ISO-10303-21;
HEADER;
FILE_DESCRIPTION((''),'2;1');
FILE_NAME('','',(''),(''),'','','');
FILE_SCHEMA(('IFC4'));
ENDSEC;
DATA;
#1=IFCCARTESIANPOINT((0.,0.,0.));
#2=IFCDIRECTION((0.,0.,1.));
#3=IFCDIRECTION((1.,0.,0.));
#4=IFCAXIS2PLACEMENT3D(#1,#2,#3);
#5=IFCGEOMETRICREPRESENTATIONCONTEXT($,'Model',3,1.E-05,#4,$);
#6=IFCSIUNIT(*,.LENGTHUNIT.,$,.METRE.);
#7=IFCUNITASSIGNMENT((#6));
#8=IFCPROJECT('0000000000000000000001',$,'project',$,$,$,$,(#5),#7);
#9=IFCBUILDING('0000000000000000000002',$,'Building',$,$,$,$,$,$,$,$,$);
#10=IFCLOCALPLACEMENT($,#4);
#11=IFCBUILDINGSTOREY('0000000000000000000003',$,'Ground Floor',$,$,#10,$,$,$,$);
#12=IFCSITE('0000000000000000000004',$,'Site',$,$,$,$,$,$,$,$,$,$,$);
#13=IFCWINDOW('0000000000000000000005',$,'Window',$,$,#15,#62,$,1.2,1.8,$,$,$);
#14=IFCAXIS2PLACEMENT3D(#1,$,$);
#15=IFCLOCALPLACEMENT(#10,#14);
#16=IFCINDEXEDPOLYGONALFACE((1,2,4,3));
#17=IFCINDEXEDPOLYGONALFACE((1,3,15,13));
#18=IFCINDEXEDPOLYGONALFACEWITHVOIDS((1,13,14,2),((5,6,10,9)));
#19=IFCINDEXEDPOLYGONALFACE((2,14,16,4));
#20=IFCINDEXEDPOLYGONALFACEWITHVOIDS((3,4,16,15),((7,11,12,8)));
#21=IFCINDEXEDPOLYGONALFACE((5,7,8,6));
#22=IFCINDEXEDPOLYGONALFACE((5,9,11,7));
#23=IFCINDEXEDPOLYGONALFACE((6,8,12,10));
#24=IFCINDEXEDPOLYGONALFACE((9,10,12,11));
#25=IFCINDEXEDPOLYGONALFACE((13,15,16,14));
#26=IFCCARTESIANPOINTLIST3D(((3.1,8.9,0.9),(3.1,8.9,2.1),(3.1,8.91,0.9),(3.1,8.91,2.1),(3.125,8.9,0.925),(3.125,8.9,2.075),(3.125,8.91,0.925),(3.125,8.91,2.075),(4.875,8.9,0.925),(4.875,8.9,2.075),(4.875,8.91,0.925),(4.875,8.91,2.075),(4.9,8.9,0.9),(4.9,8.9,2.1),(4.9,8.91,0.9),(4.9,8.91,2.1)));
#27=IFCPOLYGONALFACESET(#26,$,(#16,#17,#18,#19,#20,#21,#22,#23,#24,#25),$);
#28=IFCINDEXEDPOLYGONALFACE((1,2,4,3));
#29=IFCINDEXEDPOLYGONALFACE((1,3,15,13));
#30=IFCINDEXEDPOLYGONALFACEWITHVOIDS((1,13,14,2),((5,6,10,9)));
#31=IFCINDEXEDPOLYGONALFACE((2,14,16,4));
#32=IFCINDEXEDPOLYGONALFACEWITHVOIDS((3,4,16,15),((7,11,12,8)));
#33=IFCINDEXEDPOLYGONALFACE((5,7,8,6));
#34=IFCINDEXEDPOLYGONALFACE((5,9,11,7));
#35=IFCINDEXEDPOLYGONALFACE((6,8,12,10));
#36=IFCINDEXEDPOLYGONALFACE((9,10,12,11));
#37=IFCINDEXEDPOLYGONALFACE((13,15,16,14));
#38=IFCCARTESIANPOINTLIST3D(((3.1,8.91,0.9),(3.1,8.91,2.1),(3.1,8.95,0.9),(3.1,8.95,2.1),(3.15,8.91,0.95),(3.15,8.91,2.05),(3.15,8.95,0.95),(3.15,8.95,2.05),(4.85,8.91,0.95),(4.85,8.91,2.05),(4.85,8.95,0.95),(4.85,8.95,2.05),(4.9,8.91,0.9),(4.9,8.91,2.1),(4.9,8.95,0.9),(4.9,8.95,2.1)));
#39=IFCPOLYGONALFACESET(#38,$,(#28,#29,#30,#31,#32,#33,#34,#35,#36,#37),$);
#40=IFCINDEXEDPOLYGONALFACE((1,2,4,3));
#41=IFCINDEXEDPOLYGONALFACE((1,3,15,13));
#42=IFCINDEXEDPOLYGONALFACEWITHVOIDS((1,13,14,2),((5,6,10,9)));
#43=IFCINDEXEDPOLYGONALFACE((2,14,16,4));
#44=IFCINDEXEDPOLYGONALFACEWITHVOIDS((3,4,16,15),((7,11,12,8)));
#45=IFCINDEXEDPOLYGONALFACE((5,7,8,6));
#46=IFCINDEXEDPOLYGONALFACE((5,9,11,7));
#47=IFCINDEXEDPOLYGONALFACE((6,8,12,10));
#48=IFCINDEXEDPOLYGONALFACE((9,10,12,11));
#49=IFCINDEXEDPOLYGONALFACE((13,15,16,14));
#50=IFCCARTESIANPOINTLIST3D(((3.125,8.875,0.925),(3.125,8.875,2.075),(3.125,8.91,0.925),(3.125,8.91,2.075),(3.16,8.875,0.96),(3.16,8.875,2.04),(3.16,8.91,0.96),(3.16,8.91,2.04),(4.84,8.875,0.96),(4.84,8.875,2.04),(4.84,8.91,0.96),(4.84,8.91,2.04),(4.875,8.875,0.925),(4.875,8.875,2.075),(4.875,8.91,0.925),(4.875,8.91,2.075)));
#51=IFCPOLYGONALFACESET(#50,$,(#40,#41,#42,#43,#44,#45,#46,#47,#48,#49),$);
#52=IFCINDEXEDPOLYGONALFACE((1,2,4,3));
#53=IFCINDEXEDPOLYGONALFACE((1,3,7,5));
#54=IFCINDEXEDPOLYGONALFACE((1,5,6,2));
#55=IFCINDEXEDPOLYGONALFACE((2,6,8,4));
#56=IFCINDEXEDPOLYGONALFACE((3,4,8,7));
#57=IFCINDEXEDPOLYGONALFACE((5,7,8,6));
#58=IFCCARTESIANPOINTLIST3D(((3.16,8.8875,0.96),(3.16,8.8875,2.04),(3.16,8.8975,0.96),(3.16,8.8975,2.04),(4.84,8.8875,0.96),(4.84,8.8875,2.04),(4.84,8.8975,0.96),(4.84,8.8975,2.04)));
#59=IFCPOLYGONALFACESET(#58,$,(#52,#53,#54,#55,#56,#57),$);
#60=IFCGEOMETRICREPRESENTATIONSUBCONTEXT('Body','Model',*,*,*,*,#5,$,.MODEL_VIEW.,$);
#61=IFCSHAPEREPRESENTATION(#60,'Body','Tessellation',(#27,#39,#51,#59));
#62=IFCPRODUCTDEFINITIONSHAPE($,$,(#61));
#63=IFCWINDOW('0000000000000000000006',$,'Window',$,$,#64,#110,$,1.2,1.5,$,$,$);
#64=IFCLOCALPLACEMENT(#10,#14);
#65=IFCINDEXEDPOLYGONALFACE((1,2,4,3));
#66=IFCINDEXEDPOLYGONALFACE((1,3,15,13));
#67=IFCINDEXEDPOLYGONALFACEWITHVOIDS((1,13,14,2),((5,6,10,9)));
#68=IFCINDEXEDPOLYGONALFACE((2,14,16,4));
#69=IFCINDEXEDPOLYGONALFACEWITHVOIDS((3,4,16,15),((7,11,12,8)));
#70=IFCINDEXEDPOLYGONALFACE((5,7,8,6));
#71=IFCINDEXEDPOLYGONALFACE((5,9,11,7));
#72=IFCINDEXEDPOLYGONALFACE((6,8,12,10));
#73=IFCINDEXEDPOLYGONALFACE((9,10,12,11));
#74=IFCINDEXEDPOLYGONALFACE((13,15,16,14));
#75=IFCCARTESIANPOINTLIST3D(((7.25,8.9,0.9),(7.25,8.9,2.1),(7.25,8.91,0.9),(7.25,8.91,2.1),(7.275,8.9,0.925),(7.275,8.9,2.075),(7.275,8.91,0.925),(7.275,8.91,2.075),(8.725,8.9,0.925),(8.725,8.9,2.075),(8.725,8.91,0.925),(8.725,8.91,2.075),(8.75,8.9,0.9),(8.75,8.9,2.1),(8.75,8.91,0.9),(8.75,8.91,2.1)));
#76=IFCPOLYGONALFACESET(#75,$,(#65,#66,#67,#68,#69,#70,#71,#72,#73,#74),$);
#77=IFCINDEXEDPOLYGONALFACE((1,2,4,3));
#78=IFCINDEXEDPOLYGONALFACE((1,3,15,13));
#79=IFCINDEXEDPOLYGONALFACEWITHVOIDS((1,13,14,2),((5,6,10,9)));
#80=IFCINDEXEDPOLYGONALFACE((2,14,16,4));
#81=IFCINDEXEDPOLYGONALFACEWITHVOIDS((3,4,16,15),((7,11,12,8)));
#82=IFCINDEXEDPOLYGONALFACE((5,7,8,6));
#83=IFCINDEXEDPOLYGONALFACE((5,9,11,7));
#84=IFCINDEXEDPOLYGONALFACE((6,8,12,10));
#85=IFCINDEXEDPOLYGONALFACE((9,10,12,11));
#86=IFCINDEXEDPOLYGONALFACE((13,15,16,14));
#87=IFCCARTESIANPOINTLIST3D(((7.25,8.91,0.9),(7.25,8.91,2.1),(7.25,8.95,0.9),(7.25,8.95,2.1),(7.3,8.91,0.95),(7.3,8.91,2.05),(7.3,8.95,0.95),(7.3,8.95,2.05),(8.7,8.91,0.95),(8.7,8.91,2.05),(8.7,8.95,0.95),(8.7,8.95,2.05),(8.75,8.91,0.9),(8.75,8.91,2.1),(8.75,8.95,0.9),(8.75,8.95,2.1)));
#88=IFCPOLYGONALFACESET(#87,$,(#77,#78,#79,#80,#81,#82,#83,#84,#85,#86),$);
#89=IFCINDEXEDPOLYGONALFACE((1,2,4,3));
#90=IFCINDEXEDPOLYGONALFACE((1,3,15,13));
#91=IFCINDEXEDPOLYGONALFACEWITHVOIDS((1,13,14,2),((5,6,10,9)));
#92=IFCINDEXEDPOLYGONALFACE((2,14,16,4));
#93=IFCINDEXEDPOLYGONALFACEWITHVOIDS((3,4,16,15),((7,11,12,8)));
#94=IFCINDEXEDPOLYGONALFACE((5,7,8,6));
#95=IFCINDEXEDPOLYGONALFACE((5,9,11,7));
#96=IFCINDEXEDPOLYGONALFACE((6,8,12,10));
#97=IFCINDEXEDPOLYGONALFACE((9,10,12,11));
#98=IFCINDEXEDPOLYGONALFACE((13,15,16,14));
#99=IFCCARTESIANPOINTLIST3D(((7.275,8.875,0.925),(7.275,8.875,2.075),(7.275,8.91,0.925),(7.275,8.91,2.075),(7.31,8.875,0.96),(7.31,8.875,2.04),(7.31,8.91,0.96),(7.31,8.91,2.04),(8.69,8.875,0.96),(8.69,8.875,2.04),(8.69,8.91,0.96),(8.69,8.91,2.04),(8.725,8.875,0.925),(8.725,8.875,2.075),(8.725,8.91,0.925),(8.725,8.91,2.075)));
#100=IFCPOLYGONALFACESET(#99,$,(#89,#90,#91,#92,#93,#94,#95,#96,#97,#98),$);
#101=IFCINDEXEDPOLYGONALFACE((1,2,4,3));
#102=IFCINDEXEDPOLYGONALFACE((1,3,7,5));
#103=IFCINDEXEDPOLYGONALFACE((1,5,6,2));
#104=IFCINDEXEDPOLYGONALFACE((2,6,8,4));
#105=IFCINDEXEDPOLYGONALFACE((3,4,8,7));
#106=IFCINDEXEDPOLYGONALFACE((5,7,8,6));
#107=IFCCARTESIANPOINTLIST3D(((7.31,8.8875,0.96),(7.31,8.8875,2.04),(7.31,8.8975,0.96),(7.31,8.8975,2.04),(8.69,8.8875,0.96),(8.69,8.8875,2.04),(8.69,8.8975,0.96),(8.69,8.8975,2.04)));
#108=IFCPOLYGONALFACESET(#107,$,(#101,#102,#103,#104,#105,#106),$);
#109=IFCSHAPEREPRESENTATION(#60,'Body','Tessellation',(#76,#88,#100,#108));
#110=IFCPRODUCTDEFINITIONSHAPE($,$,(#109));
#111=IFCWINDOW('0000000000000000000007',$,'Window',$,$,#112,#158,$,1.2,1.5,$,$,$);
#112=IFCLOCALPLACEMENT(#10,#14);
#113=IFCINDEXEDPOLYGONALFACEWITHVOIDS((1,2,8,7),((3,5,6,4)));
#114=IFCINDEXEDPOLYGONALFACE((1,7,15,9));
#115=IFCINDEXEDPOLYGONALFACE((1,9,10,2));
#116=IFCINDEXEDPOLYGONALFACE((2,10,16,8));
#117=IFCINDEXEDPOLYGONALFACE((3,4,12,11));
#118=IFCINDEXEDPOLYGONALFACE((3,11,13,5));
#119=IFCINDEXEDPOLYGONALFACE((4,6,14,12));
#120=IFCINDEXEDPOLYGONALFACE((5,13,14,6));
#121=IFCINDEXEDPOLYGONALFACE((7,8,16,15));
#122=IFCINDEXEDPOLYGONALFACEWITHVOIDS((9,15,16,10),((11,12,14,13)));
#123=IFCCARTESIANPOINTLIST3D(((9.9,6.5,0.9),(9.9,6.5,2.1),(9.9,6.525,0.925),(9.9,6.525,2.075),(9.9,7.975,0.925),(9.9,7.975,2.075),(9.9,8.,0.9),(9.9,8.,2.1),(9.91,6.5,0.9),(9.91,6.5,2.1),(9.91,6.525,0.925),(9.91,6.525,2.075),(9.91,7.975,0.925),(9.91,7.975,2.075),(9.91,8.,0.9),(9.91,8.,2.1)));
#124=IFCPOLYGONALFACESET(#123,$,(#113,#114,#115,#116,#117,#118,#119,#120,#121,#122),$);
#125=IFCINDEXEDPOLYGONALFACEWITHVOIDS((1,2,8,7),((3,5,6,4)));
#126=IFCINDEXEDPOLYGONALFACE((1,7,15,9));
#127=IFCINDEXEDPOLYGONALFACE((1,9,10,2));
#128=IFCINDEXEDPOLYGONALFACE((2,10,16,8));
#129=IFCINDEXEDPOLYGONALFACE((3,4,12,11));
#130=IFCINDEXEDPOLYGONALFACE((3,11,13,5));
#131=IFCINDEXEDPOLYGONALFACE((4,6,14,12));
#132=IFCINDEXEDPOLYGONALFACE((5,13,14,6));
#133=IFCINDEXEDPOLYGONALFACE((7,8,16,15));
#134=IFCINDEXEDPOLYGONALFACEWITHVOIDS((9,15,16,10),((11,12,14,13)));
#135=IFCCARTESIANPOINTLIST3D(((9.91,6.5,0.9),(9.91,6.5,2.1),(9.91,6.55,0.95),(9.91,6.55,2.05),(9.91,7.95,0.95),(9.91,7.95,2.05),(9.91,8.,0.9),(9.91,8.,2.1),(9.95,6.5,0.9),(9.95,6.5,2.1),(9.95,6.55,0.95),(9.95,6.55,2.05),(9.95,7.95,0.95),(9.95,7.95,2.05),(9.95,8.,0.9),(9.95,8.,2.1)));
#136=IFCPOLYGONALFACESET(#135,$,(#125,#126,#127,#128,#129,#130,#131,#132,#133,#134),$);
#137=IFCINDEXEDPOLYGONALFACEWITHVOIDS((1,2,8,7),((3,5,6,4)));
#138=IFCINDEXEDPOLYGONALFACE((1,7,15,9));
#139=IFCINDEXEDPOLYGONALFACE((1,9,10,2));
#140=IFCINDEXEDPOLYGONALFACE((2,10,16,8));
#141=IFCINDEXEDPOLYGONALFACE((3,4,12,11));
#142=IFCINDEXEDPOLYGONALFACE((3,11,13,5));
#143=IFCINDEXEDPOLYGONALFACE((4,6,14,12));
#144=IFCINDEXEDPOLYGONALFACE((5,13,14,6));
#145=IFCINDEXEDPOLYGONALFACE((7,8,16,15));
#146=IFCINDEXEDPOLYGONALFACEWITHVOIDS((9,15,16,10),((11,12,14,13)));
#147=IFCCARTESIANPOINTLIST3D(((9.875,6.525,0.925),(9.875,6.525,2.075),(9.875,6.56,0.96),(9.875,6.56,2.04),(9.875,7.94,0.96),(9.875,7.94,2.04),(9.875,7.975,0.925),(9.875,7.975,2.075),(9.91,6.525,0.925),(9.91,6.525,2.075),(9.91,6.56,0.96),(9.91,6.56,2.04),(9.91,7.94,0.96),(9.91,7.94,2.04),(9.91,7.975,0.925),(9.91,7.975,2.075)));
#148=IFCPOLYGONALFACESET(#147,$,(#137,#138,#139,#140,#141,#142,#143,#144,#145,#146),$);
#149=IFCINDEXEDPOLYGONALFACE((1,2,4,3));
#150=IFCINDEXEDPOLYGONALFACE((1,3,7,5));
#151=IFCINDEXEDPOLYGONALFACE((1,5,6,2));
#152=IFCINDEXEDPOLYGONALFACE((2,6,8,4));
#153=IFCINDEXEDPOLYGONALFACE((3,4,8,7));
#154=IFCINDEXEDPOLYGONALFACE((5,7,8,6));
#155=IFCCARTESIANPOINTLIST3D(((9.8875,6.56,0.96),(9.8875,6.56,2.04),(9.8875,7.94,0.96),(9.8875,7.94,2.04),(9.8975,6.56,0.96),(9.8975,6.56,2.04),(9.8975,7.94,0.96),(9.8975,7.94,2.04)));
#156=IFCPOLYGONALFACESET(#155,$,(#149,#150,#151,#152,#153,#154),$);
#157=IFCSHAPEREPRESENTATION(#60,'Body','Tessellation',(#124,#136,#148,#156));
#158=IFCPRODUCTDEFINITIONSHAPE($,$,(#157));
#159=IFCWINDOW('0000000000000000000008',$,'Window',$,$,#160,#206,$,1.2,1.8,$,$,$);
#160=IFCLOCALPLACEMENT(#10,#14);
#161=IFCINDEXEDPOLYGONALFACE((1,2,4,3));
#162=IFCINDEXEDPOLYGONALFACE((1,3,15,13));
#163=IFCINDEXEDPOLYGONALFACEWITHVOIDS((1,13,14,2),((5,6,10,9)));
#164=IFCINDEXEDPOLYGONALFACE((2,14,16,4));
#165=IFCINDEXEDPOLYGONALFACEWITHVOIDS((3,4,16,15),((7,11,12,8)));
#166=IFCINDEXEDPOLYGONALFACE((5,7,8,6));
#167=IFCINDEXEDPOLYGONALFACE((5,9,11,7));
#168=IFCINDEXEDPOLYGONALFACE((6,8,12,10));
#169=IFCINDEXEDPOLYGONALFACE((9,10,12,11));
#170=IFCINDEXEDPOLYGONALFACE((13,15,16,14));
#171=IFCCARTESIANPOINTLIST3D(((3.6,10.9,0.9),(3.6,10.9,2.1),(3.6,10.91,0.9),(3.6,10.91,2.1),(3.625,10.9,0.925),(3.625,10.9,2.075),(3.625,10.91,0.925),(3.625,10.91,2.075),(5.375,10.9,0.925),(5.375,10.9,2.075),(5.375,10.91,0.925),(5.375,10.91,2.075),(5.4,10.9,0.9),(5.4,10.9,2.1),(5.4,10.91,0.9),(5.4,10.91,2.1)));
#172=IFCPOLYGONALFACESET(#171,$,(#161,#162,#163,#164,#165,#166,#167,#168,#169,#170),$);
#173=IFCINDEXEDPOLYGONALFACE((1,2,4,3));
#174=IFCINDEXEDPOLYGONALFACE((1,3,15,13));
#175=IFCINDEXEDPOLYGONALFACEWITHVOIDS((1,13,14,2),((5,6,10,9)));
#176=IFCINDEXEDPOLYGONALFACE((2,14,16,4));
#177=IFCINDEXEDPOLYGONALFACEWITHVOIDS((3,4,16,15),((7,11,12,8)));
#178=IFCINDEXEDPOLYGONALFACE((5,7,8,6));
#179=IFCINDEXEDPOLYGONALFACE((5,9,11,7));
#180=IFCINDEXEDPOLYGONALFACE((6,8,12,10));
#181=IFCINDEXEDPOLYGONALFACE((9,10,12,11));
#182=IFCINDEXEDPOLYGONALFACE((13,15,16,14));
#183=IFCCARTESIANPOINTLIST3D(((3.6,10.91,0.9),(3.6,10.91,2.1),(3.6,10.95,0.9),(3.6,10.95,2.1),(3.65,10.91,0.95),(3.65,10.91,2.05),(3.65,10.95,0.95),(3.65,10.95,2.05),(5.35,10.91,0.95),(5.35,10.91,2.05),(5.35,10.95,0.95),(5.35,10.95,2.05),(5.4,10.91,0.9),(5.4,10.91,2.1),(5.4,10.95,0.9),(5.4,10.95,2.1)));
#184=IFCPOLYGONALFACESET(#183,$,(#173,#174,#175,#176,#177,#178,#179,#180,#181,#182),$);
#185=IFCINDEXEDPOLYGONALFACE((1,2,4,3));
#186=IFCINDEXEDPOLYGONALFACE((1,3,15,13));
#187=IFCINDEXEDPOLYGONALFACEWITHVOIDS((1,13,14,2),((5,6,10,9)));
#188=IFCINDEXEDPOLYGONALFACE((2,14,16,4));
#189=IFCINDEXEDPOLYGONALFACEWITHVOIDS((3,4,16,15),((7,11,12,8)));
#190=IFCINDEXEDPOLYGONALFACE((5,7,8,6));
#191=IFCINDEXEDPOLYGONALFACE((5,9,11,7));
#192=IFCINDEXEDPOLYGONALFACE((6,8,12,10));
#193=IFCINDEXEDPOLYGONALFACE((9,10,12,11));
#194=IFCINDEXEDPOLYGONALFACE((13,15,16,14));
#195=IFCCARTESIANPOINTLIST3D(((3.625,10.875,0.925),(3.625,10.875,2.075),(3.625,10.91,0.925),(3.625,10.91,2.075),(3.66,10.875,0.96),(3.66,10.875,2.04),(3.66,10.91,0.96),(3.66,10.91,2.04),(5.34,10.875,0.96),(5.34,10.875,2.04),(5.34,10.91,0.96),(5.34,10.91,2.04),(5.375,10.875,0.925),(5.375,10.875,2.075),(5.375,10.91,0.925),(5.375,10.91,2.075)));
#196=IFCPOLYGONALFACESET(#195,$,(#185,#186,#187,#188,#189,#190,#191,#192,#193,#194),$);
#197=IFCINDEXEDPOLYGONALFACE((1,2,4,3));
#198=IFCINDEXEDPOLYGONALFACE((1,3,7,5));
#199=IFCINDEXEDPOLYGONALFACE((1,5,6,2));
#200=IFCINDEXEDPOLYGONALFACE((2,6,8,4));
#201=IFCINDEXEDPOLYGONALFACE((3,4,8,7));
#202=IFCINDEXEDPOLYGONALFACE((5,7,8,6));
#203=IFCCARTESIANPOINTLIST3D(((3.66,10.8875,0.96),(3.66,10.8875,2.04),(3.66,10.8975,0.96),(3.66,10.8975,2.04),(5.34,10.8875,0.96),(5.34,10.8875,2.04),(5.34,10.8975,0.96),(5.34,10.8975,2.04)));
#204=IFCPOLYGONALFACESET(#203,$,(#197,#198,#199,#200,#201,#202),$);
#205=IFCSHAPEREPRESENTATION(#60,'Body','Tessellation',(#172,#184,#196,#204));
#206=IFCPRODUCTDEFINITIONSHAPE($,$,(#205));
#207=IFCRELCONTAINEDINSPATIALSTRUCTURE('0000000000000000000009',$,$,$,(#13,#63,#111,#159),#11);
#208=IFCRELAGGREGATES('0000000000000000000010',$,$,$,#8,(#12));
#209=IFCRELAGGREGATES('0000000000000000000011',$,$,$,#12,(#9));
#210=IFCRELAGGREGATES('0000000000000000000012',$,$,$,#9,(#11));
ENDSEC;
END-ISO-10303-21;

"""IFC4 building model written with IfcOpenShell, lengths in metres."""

from ifc_helpers import new_model, si_unit, frame, origin_with_axes, place, context, subcontext, project, spatial, line, indexed_curve, outline, extrude, element, save


model = new_model("IFC4")

# Units and contexts
model_context = context("Model", 3, precision=1e-05, world=origin_with_axes())
body_context = subcontext(model_context, "Body", "Model", "MODEL_VIEW")
ifc_project = project(units=[si_unit("LENGTHUNIT", "METRE")], contexts=[model_context])

# Site, building, storey
site = spatial("IfcSite", under=ifc_project, Name="Site")
building = spatial("IfcBuilding", under=site, Name="Building")
storey_placement = place(None, origin_with_axes())
storey = spatial("IfcBuildingStorey", under=building, at=storey_placement, Name="Ground Floor")

# Windows
window_1_placement = place(storey_placement, frame((4.9, 9.0, 0.9), z_axis=(0.0, 0.0, 1.0), x_axis=(-1.0, 0.0, 0.0)))
element("IfcWindow", 1, at=window_1_placement, inside=storey, Name="Window", OverallHeight=1.2, OverallWidth=1.8, context=body_context, shape_type="SweptSolid", body=[
    extrude(outline(indexed_curve([(0.0, 0.0), (1.8, 0.0), (1.8, 1.2), (0.0, 1.2)], segments=[line(1, 2, 3, 4, 1)]), holes=[indexed_curve([(0.025, 0.025), (1.775, 0.025), (1.775, 1.175), (0.025, 1.175)], segments=[line(1, 2, 3, 4, 1)])]), frame((0.0, 0.09, 0.0), z_axis=(0.0, -1.0, 0.0), x_axis=(1.0, 0.0, 0.0)), (0.0, 0.0, -1.0), 0.01),
    extrude(outline(indexed_curve([(0.0, 0.0), (1.8, 0.0), (1.8, 1.2), (0.0, 1.2)], segments=[line(1, 2, 3, 4, 1)]), holes=[indexed_curve([(0.05, 0.05), (1.75, 0.05), (1.75, 1.15), (0.05, 1.15)], segments=[line(1, 2, 3, 4, 1)])]), frame((0.0, 0.05, 0.0), z_axis=(0.0, -1.0, 0.0), x_axis=(1.0, 0.0, 0.0)), (0.0, 0.0, -1.0), 0.04),
    extrude(outline(indexed_curve([(0.0, 0.0), (1.75, 0.0), (1.75, 1.15), (0.0, 1.15)], segments=[line(1, 2, 3, 4, 1)]), holes=[indexed_curve([(0.035, 0.035), (1.715, 0.035), (1.715, 1.115), (0.035, 1.115)], segments=[line(1, 2, 3, 4, 1)])]), frame((0.025, 0.09, 0.025), z_axis=(0.0, -1.0, 0.0), x_axis=(1.0, 0.0, 0.0)), (0.0, 0.0, -1.0), 0.035),
    extrude(outline(indexed_curve([(0.035, 0.035), (1.715, 0.035), (1.715, 1.115), (0.035, 1.115)], segments=[line(1, 2, 3, 4, 1)])), frame((0.025, 0.1025, 0.025), z_axis=(0.0, -1.0, 0.0), x_axis=(1.0, 0.0, 0.0)), (0.0, 0.0, -1.0), 0.01),
])
for number, where, z_axis, x_axis, name in (
    (2, (8.75, 9.0, 0.9), (0.0, 0.0, 1.0), (-1.0, 0.0, 0.0), "Window"),
    (3, (10.0, 6.5, 0.9), (0.0, 0.0, 1.0), (0.0, 1.0, 0.0), "Window"),
):
    element("IfcWindow", number, at=place(storey_placement, frame(where, z_axis=z_axis, x_axis=x_axis)), inside=storey, Name=name, OverallHeight=1.2, OverallWidth=1.5, context=body_context, shape_type="SweptSolid", body=[
        extrude(outline(indexed_curve([(0.0, 0.0), (1.5, 0.0), (1.5, 1.2), (0.0, 1.2)], segments=[line(1, 2, 3, 4, 1)]), holes=[indexed_curve([(0.025, 0.025), (1.475, 0.025), (1.475, 1.175), (0.025, 1.175)], segments=[line(1, 2, 3, 4, 1)])]), frame((0.0, 0.09, 0.0), z_axis=(0.0, -1.0, 0.0), x_axis=(1.0, 0.0, 0.0)), (0.0, 0.0, -1.0), 0.01),
        extrude(outline(indexed_curve([(0.0, 0.0), (1.5, 0.0), (1.5, 1.2), (0.0, 1.2)], segments=[line(1, 2, 3, 4, 1)]), holes=[indexed_curve([(0.05, 0.05), (1.45, 0.05), (1.45, 1.15), (0.05, 1.15)], segments=[line(1, 2, 3, 4, 1)])]), frame((0.0, 0.05, 0.0), z_axis=(0.0, -1.0, 0.0), x_axis=(1.0, 0.0, 0.0)), (0.0, 0.0, -1.0), 0.04),
        extrude(outline(indexed_curve([(0.0, 0.0), (1.45, 0.0), (1.45, 1.15), (0.0, 1.15)], segments=[line(1, 2, 3, 4, 1)]), holes=[indexed_curve([(0.035, 0.035), (1.415, 0.035), (1.415, 1.115), (0.035, 1.115)], segments=[line(1, 2, 3, 4, 1)])]), frame((0.025, 0.09, 0.025), z_axis=(0.0, -1.0, 0.0), x_axis=(1.0, 0.0, 0.0)), (0.0, 0.0, -1.0), 0.035),
        extrude(outline(indexed_curve([(0.035, 0.035), (1.415, 0.035), (1.415, 1.115), (0.035, 1.115)], segments=[line(1, 2, 3, 4, 1)])), frame((0.025, 0.1025, 0.025), z_axis=(0.0, -1.0, 0.0), x_axis=(1.0, 0.0, 0.0)), (0.0, 0.0, -1.0), 0.01),
    ])
window_2_placement = place(storey_placement, frame((5.4, 11.0, 0.9), z_axis=(0.0, 0.0, 1.0), x_axis=(-1.0, 0.0, 0.0)))
element("IfcWindow", 4, at=window_2_placement, inside=storey, Name="Window", OverallHeight=1.2, OverallWidth=1.8, context=body_context, shape_type="SweptSolid", body=[
    extrude(outline(indexed_curve([(0.0, 0.0), (1.8, 0.0), (1.8, 1.2), (0.0, 1.2)], segments=[line(1, 2, 3, 4, 1)]), holes=[indexed_curve([(0.025, 0.025), (1.775, 0.025), (1.775, 1.175), (0.025, 1.175)], segments=[line(1, 2, 3, 4, 1)])]), frame((0.0, 0.09, 0.0), z_axis=(0.0, -1.0, 0.0), x_axis=(1.0, 0.0, 0.0)), (0.0, 0.0, -1.0), 0.01),
    extrude(outline(indexed_curve([(0.0, 0.0), (1.8, 0.0), (1.8, 1.2), (0.0, 1.2)], segments=[line(1, 2, 3, 4, 1)]), holes=[indexed_curve([(0.05, 0.05), (1.75, 0.05), (1.75, 1.15), (0.05, 1.15)], segments=[line(1, 2, 3, 4, 1)])]), frame((0.0, 0.05, 0.0), z_axis=(0.0, -1.0, 0.0), x_axis=(1.0, 0.0, 0.0)), (0.0, 0.0, -1.0), 0.04),
    extrude(outline(indexed_curve([(0.0, 0.0), (1.75, 0.0), (1.75, 1.15), (0.0, 1.15)], segments=[line(1, 2, 3, 4, 1)]), holes=[indexed_curve([(0.035, 0.035), (1.715, 0.035), (1.715, 1.115), (0.035, 1.115)], segments=[line(1, 2, 3, 4, 1)])]), frame((0.025, 0.09, 0.025), z_axis=(0.0, -1.0, 0.0), x_axis=(1.0, 0.0, 0.0)), (0.0, 0.0, -1.0), 0.035),
    extrude(outline(indexed_curve([(0.035, 0.035), (1.715, 0.035), (1.715, 1.115), (0.035, 1.115)], segments=[line(1, 2, 3, 4, 1)])), frame((0.025, 0.1025, 0.025), z_axis=(0.0, -1.0, 0.0), x_axis=(1.0, 0.0, 0.0)), (0.0, 0.0, -1.0), 0.01),
])

save(model, "model.ifc")
